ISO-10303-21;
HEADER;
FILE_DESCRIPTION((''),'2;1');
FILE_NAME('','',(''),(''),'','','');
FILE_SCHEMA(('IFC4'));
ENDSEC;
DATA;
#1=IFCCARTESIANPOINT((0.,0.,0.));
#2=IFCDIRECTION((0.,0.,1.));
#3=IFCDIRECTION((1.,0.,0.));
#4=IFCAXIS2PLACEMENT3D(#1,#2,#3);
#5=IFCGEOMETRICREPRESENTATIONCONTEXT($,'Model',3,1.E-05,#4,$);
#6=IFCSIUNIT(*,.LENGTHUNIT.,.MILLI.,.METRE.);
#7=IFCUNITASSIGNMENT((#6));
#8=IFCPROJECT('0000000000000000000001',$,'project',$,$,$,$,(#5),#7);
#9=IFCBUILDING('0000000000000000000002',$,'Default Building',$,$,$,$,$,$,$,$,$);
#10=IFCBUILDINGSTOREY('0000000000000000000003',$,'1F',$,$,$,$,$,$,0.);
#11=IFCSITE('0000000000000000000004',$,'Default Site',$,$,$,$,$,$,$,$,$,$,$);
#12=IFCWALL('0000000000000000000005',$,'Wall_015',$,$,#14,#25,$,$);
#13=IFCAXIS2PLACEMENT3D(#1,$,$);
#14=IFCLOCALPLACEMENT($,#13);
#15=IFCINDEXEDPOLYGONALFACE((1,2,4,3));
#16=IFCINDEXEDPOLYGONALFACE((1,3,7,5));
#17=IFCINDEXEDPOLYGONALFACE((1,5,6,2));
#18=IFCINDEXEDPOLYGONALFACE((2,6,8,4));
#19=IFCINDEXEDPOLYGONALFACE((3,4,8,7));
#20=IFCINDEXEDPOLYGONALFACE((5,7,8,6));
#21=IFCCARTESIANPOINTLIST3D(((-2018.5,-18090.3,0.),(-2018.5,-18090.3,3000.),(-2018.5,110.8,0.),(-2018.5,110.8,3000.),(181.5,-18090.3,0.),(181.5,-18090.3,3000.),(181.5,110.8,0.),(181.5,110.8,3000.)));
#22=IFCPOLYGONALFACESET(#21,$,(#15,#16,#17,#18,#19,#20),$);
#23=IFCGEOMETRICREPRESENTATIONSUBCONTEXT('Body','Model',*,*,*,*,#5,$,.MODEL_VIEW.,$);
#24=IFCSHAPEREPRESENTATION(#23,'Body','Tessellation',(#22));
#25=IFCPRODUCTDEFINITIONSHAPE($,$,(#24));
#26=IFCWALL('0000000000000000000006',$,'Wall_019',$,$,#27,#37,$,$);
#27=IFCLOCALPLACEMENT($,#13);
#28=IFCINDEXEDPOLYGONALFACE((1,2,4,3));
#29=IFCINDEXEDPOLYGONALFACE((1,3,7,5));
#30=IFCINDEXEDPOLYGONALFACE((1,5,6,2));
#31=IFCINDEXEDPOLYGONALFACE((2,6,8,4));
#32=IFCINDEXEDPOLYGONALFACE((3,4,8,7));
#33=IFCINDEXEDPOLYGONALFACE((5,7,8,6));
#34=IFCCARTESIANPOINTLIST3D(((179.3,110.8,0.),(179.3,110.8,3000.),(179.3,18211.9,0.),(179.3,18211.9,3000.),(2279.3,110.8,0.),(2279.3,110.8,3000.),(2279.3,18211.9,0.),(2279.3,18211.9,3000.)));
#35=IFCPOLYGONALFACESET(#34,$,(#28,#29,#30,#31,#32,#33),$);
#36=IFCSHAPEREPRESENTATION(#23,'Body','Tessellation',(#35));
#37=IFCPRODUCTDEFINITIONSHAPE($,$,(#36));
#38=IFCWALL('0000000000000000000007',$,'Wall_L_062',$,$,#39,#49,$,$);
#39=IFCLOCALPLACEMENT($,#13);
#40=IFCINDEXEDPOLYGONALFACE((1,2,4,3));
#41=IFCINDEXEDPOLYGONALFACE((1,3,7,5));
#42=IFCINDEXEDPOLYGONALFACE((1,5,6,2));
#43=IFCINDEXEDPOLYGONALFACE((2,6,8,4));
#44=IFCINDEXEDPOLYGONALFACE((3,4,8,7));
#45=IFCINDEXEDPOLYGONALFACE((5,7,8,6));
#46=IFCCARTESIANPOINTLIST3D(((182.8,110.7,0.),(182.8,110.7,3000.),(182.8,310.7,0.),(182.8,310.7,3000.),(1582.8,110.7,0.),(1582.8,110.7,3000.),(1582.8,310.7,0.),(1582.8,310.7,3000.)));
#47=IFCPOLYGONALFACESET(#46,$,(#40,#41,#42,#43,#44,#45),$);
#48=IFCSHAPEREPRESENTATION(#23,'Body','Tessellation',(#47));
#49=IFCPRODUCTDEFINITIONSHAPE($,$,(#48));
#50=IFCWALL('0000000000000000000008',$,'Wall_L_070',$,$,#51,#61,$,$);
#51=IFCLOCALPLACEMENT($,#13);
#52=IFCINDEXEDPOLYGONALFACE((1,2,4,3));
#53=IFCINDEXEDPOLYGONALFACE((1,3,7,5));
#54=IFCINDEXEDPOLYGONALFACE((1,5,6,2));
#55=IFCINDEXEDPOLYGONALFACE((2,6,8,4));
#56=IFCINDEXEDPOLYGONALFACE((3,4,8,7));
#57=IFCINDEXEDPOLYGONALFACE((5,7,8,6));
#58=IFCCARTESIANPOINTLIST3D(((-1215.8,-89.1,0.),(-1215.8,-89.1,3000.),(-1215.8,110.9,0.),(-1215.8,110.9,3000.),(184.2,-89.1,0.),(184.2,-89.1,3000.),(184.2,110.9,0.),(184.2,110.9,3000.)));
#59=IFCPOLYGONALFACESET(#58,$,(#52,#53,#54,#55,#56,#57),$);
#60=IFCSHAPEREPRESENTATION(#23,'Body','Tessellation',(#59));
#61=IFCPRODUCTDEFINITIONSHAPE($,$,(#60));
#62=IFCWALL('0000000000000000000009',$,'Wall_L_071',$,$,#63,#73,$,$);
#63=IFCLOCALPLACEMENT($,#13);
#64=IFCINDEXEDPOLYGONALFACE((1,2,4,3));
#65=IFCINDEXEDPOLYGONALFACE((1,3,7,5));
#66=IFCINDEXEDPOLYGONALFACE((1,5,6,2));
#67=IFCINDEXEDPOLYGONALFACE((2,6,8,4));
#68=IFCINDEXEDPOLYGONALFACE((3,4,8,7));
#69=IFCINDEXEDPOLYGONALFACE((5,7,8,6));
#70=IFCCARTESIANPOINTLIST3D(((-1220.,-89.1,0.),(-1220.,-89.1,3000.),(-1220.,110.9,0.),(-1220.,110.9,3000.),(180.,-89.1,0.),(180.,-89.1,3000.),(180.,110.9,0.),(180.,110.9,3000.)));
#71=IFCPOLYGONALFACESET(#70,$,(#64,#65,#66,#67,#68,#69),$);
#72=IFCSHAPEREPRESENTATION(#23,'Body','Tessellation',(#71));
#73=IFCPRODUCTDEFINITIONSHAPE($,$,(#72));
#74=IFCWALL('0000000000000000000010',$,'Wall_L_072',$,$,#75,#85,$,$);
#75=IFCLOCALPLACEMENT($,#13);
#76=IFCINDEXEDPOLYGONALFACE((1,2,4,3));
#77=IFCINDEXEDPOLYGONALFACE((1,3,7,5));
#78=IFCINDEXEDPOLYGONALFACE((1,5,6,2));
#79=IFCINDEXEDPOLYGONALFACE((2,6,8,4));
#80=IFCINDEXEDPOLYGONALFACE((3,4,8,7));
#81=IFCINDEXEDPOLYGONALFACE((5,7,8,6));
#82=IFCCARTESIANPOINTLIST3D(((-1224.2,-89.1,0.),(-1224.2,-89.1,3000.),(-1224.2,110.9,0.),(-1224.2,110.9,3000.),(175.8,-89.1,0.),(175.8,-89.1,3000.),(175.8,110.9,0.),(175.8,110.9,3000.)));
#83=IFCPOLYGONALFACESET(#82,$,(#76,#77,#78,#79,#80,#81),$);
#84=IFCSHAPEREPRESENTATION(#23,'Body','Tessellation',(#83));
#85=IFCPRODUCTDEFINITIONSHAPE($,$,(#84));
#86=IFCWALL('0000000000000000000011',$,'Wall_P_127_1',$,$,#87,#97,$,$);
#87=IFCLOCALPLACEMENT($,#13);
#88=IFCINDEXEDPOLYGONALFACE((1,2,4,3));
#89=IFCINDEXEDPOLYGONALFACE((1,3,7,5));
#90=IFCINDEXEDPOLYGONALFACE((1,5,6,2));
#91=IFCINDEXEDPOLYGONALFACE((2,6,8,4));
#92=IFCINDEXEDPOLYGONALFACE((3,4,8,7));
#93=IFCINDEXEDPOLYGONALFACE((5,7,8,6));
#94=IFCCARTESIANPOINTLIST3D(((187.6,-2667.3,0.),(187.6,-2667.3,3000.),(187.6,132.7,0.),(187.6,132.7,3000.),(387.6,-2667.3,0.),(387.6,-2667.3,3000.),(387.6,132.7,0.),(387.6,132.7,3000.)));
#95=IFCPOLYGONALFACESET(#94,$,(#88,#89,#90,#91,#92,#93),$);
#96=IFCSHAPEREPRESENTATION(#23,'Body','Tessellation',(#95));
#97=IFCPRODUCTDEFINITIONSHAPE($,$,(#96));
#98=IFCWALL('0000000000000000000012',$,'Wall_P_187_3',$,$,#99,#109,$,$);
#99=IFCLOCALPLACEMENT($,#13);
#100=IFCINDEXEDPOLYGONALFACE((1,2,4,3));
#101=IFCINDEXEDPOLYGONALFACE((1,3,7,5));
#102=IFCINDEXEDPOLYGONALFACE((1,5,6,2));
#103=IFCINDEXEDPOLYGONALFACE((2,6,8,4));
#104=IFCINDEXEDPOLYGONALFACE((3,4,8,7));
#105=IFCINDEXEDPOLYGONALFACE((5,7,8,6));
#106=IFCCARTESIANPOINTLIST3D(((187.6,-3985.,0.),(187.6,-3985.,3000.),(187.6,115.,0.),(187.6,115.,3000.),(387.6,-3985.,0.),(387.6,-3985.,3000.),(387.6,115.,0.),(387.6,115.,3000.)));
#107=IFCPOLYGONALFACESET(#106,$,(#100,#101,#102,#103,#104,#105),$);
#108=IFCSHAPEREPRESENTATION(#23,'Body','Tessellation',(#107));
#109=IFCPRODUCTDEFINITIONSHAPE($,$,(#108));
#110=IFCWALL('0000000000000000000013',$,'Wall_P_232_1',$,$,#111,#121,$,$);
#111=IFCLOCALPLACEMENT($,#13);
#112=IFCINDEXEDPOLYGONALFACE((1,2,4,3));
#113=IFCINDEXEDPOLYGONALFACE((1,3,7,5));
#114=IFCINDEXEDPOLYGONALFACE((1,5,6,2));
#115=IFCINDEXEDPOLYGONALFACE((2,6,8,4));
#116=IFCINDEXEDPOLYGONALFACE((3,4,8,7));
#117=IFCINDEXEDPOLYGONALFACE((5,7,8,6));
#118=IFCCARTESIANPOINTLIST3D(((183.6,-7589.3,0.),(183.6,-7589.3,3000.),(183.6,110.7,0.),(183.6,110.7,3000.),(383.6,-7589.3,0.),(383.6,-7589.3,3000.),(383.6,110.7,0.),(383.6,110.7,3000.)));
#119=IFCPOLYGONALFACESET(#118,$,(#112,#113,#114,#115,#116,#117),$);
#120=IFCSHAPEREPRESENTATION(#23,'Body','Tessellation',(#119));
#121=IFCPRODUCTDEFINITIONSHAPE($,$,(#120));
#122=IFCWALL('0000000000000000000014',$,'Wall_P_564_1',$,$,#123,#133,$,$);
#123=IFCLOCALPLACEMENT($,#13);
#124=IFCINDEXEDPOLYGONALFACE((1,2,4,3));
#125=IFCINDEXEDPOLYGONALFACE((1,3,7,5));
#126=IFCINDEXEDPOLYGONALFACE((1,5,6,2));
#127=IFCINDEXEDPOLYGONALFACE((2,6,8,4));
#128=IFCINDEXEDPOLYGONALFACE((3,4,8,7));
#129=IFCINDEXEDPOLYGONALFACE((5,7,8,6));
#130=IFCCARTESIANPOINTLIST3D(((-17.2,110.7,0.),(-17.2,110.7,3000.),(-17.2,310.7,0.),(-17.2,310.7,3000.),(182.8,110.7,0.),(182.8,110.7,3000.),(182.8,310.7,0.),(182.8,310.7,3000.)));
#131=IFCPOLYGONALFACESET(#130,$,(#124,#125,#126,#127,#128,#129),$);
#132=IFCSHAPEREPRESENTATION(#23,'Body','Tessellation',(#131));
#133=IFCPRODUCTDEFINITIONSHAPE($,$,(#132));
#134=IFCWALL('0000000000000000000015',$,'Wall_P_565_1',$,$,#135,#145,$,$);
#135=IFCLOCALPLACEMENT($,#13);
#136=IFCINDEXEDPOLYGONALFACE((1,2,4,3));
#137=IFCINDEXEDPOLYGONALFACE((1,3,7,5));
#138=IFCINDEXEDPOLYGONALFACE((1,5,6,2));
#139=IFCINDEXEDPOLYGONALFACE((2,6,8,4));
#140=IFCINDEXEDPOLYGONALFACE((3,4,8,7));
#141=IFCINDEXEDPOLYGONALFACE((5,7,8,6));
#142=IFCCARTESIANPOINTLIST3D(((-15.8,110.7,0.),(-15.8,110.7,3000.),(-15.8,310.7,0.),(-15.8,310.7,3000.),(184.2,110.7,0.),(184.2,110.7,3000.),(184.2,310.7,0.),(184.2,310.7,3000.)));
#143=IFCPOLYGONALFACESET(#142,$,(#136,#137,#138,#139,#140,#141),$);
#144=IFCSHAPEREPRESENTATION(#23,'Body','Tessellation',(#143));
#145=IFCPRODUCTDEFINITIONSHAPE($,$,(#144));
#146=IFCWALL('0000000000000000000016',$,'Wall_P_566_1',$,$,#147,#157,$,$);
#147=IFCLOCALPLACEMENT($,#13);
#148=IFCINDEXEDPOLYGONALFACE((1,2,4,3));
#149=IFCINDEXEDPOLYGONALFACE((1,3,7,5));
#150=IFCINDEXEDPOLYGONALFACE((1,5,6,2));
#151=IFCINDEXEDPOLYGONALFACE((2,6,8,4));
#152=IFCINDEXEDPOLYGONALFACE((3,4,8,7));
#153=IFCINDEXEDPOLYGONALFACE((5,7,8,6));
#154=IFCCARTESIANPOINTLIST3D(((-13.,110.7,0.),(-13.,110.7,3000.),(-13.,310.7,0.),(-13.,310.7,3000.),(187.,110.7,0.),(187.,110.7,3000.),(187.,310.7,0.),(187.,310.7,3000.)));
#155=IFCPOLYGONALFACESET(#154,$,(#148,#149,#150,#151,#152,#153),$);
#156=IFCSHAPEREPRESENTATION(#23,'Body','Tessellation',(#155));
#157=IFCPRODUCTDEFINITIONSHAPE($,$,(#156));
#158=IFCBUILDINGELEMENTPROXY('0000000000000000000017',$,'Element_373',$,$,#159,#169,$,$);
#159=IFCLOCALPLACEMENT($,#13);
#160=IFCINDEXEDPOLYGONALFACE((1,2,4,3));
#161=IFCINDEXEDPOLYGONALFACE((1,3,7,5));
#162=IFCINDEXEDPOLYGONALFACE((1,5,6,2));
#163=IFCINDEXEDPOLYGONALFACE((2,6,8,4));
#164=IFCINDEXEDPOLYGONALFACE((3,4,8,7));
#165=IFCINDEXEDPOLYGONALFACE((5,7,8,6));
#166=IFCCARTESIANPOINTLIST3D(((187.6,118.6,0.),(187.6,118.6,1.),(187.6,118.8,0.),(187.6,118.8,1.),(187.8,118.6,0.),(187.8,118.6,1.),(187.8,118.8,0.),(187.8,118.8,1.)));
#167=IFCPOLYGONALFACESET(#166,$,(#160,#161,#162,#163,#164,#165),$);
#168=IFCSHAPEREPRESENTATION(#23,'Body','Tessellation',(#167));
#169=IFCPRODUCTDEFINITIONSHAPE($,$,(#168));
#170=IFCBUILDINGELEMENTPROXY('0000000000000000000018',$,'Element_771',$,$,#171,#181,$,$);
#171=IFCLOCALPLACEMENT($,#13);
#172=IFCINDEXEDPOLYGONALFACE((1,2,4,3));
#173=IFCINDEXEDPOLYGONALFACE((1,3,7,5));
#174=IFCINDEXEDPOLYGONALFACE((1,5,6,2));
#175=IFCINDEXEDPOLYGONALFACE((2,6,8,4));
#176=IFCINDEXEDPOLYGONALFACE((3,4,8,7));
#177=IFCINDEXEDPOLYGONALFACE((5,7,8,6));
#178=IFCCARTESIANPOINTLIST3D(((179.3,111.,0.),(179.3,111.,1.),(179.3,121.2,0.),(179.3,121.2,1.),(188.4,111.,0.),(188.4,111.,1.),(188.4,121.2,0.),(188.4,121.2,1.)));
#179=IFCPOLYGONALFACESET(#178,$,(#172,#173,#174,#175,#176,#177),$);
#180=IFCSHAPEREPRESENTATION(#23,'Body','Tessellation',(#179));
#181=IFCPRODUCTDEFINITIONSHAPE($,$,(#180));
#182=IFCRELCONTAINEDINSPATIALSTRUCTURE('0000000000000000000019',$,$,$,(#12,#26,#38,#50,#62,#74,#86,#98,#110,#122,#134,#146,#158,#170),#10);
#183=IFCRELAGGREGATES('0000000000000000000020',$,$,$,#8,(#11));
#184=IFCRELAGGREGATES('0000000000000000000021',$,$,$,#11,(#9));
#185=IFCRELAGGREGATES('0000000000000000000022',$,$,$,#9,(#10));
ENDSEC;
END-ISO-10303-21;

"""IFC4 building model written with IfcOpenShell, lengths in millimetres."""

from ifc_helpers import new_model, si_unit, frame, origin, origin_with_axes, place, context, subcontext, project, spatial, polyline, indexed_curve, rectangle, outline, extrude, element, save


model = new_model("IFC4")

# Units and contexts
model_context = context("Model", 3, precision=1e-05, world=origin_with_axes())
body_context = subcontext(model_context, "Body", "Model", "MODEL_VIEW")
ifc_project = project(units=[si_unit("LENGTHUNIT", "METRE", prefix="MILLI")], contexts=[model_context])

# Site, building, storey
site = spatial("IfcSite", under=ifc_project, Name="Default Site")
building = spatial("IfcBuilding", under=site, Name="Default Building")
storey = spatial("IfcBuildingStorey", under=building, Name="1F", Elevation=0.0)

# Walls
wall_1_placement = place(None, frame((181.5, 110.8, 0.0), z_axis=(0.0, 0.0, 1.0), x_axis=(-1.0, 0.0, 0.0)))
element("IfcWall", 1, at=wall_1_placement, inside=storey, Name="Wall_015", context=body_context, shape_type="SweptSolid", body=[
    extrude(outline(indexed_curve([(0.0, 0.0), (0.0, 18201.1), (2200.0, 18201.1), (2200.0, 0.0), (0.0, 0.0)], self_intersect=False)), origin_with_axes(), (0.0, 0.0, 1.0), 3000.0),
])
wall_2_placement = place(None, frame((179.3, 110.8, 0.0), z_axis=(0.0, 0.0, 1.0), x_axis=(1.0, 0.0, 0.0)))
element("IfcWall", 2, at=wall_2_placement, inside=storey, Name="Wall_019", context=body_context, shape_type="SweptSolid", body=[
    extrude(outline(indexed_curve([(0.0, 0.0), (0.0, 18101.1), (2100.0, 18101.1), (2100.0, 0.0), (0.0, 0.0)], self_intersect=False)), origin_with_axes(), (0.0, 0.0, 1.0), 3000.0),
])
for number, where, z_axis, x_axis, name in (
    (3, (182.8, 110.7, 0.0), (0.0, 0.0, 1.0), (1.0, 0.0, 0.0), "Wall_L_062"),
    (4, (184.2, 110.9, 0.0), (0.0, 0.0, 1.0), (-1.0, 0.0, 0.0), "Wall_L_070"),
):
    element("IfcWall", number, at=place(None, frame(where, z_axis=z_axis, x_axis=x_axis)), inside=storey, Name=name, context=body_context, shape_type="SweptSolid", body=[
        extrude(outline(indexed_curve([(0.0, 0.0), (0.0, 200.0), (1400.0, 200.0), (1400.0, 0.0), (0.0, 0.0)], self_intersect=False)), origin_with_axes(), (0.0, 0.0, 1.0), 3000.0),
    ])
for number, where, z_axis, x_axis, name in (
    (5, (180.0, 110.9, 0.0), (0.0, 0.0, 1.0), (-1.0, 0.0, 0.0), "Wall_L_071"),
    (6, (175.8, 110.9, 0.0), (0.0, 0.0, 1.0), (-1.0, 0.0, 0.0), "Wall_L_072"),
):
    element("IfcWall", number, at=place(None, frame(where, z_axis=z_axis, x_axis=x_axis)), inside=storey, Name=name, context=body_context, shape_type="SweptSolid", body=[
        extrude(outline(indexed_curve([(0.0, 0.0), (0.0, 200.0), (1400.0, 200.0), (1400.0, 0.0), (0.0, 0.0)], self_intersect=False)), origin_with_axes(), (0.0, 0.0, 1.0), 3000.0),
    ])
wall_3_placement = place(None, frame((187.6, 132.7, 0.0), z_axis=(0.0, 0.0, 1.0), x_axis=(0.0, -1.0, 0.0)))
element("IfcWall", 7, at=wall_3_placement, inside=storey, Name="Wall_P_127_1", context=body_context, shape_type="SweptSolid", body=[
    extrude(outline(indexed_curve([(0.0, 0.0), (0.0, 200.0), (2800.0, 200.0), (2800.0, 0.0), (0.0, 0.0)], self_intersect=False)), origin_with_axes(), (0.0, 0.0, 1.0), 3000.0),
])
wall_4_placement = place(None, frame((187.6, 115.0, 0.0), z_axis=(0.0, 0.0, 1.0), x_axis=(0.0, -1.0, 0.0)))
element("IfcWall", 8, at=wall_4_placement, inside=storey, Name="Wall_P_187_3", context=body_context, shape_type="SweptSolid", body=[
    extrude(outline(indexed_curve([(0.0, 0.0), (0.0, 200.0), (4100.0, 200.0), (4100.0, 0.0), (0.0, 0.0)], self_intersect=False)), origin_with_axes(), (0.0, 0.0, 1.0), 3000.0),
])
wall_5_placement = place(None, frame((183.6, 110.7, 0.0), z_axis=(0.0, 0.0, 1.0), x_axis=(0.0, -1.0, 0.0)))
element("IfcWall", 9, at=wall_5_placement, inside=storey, Name="Wall_P_232_1", context=body_context, shape_type="SweptSolid", body=[
    extrude(outline(indexed_curve([(0.0, 0.0), (0.0, 200.0), (7700.0, 200.0), (7700.0, 0.0), (0.0, 0.0)], self_intersect=False)), origin_with_axes(), (0.0, 0.0, 1.0), 3000.0),
])
for number, where, z_axis, x_axis, name in (
    (10, (182.8, 110.7, 0.0), (0.0, 0.0, 1.0), (0.0, 1.0, 0.0), "Wall_P_564_1"),
    (11, (184.2, 110.7, 0.0), (0.0, 0.0, 1.0), (0.0, 1.0, 0.0), "Wall_P_565_1"),
    (12, (187.0, 110.7, 0.0), (0.0, 0.0, 1.0), (0.0, 1.0, 0.0), "Wall_P_566_1"),
):
    element("IfcWall", number, at=place(None, frame(where, z_axis=z_axis, x_axis=x_axis)), inside=storey, Name=name, context=body_context, shape_type="SweptSolid", body=[
        extrude(outline(indexed_curve([(0.0, 0.0), (0.0, 200.0), (200.0, 200.0), (200.0, 0.0), (0.0, 0.0)], self_intersect=False)), origin_with_axes(), (0.0, 0.0, 1.0), 3000.0),
    ])

# Building element proxies
proxy_1_placement = place(None, frame((187.7, 118.7, 0.0), z_axis=(0.0, 0.0, 1.0), x_axis=(1.0, 0.0, 0.0)))
element("IfcBuildingElementProxy", 13, at=proxy_1_placement, inside=storey, Name="Element_373", context=body_context, shape_type="SweptSolid", body=[
    extrude(outline(polyline([(0.1, -0.1), (-0.1, -0.1), (-0.1, 0.1), (0.1, 0.1), (0.1, -0.1)])), origin(), (0.0, 0.0, 1.0), 1.0),
])
proxy_2_placement = place(None, frame((183.9, 116.1, 0.0), z_axis=(0.0, 0.0, 1.0), x_axis=(1.0, 0.0, 0.0)))
element("IfcBuildingElementProxy", 14, at=proxy_2_placement, inside=storey, Name="Element_771", context=body_context, shape_type="SweptSolid", body=[
    extrude(rectangle(XDim=9.1, YDim=10.2), origin(), (0.0, 0.0, 1.0), 1.0),
])

save(model, "model.ifc")
